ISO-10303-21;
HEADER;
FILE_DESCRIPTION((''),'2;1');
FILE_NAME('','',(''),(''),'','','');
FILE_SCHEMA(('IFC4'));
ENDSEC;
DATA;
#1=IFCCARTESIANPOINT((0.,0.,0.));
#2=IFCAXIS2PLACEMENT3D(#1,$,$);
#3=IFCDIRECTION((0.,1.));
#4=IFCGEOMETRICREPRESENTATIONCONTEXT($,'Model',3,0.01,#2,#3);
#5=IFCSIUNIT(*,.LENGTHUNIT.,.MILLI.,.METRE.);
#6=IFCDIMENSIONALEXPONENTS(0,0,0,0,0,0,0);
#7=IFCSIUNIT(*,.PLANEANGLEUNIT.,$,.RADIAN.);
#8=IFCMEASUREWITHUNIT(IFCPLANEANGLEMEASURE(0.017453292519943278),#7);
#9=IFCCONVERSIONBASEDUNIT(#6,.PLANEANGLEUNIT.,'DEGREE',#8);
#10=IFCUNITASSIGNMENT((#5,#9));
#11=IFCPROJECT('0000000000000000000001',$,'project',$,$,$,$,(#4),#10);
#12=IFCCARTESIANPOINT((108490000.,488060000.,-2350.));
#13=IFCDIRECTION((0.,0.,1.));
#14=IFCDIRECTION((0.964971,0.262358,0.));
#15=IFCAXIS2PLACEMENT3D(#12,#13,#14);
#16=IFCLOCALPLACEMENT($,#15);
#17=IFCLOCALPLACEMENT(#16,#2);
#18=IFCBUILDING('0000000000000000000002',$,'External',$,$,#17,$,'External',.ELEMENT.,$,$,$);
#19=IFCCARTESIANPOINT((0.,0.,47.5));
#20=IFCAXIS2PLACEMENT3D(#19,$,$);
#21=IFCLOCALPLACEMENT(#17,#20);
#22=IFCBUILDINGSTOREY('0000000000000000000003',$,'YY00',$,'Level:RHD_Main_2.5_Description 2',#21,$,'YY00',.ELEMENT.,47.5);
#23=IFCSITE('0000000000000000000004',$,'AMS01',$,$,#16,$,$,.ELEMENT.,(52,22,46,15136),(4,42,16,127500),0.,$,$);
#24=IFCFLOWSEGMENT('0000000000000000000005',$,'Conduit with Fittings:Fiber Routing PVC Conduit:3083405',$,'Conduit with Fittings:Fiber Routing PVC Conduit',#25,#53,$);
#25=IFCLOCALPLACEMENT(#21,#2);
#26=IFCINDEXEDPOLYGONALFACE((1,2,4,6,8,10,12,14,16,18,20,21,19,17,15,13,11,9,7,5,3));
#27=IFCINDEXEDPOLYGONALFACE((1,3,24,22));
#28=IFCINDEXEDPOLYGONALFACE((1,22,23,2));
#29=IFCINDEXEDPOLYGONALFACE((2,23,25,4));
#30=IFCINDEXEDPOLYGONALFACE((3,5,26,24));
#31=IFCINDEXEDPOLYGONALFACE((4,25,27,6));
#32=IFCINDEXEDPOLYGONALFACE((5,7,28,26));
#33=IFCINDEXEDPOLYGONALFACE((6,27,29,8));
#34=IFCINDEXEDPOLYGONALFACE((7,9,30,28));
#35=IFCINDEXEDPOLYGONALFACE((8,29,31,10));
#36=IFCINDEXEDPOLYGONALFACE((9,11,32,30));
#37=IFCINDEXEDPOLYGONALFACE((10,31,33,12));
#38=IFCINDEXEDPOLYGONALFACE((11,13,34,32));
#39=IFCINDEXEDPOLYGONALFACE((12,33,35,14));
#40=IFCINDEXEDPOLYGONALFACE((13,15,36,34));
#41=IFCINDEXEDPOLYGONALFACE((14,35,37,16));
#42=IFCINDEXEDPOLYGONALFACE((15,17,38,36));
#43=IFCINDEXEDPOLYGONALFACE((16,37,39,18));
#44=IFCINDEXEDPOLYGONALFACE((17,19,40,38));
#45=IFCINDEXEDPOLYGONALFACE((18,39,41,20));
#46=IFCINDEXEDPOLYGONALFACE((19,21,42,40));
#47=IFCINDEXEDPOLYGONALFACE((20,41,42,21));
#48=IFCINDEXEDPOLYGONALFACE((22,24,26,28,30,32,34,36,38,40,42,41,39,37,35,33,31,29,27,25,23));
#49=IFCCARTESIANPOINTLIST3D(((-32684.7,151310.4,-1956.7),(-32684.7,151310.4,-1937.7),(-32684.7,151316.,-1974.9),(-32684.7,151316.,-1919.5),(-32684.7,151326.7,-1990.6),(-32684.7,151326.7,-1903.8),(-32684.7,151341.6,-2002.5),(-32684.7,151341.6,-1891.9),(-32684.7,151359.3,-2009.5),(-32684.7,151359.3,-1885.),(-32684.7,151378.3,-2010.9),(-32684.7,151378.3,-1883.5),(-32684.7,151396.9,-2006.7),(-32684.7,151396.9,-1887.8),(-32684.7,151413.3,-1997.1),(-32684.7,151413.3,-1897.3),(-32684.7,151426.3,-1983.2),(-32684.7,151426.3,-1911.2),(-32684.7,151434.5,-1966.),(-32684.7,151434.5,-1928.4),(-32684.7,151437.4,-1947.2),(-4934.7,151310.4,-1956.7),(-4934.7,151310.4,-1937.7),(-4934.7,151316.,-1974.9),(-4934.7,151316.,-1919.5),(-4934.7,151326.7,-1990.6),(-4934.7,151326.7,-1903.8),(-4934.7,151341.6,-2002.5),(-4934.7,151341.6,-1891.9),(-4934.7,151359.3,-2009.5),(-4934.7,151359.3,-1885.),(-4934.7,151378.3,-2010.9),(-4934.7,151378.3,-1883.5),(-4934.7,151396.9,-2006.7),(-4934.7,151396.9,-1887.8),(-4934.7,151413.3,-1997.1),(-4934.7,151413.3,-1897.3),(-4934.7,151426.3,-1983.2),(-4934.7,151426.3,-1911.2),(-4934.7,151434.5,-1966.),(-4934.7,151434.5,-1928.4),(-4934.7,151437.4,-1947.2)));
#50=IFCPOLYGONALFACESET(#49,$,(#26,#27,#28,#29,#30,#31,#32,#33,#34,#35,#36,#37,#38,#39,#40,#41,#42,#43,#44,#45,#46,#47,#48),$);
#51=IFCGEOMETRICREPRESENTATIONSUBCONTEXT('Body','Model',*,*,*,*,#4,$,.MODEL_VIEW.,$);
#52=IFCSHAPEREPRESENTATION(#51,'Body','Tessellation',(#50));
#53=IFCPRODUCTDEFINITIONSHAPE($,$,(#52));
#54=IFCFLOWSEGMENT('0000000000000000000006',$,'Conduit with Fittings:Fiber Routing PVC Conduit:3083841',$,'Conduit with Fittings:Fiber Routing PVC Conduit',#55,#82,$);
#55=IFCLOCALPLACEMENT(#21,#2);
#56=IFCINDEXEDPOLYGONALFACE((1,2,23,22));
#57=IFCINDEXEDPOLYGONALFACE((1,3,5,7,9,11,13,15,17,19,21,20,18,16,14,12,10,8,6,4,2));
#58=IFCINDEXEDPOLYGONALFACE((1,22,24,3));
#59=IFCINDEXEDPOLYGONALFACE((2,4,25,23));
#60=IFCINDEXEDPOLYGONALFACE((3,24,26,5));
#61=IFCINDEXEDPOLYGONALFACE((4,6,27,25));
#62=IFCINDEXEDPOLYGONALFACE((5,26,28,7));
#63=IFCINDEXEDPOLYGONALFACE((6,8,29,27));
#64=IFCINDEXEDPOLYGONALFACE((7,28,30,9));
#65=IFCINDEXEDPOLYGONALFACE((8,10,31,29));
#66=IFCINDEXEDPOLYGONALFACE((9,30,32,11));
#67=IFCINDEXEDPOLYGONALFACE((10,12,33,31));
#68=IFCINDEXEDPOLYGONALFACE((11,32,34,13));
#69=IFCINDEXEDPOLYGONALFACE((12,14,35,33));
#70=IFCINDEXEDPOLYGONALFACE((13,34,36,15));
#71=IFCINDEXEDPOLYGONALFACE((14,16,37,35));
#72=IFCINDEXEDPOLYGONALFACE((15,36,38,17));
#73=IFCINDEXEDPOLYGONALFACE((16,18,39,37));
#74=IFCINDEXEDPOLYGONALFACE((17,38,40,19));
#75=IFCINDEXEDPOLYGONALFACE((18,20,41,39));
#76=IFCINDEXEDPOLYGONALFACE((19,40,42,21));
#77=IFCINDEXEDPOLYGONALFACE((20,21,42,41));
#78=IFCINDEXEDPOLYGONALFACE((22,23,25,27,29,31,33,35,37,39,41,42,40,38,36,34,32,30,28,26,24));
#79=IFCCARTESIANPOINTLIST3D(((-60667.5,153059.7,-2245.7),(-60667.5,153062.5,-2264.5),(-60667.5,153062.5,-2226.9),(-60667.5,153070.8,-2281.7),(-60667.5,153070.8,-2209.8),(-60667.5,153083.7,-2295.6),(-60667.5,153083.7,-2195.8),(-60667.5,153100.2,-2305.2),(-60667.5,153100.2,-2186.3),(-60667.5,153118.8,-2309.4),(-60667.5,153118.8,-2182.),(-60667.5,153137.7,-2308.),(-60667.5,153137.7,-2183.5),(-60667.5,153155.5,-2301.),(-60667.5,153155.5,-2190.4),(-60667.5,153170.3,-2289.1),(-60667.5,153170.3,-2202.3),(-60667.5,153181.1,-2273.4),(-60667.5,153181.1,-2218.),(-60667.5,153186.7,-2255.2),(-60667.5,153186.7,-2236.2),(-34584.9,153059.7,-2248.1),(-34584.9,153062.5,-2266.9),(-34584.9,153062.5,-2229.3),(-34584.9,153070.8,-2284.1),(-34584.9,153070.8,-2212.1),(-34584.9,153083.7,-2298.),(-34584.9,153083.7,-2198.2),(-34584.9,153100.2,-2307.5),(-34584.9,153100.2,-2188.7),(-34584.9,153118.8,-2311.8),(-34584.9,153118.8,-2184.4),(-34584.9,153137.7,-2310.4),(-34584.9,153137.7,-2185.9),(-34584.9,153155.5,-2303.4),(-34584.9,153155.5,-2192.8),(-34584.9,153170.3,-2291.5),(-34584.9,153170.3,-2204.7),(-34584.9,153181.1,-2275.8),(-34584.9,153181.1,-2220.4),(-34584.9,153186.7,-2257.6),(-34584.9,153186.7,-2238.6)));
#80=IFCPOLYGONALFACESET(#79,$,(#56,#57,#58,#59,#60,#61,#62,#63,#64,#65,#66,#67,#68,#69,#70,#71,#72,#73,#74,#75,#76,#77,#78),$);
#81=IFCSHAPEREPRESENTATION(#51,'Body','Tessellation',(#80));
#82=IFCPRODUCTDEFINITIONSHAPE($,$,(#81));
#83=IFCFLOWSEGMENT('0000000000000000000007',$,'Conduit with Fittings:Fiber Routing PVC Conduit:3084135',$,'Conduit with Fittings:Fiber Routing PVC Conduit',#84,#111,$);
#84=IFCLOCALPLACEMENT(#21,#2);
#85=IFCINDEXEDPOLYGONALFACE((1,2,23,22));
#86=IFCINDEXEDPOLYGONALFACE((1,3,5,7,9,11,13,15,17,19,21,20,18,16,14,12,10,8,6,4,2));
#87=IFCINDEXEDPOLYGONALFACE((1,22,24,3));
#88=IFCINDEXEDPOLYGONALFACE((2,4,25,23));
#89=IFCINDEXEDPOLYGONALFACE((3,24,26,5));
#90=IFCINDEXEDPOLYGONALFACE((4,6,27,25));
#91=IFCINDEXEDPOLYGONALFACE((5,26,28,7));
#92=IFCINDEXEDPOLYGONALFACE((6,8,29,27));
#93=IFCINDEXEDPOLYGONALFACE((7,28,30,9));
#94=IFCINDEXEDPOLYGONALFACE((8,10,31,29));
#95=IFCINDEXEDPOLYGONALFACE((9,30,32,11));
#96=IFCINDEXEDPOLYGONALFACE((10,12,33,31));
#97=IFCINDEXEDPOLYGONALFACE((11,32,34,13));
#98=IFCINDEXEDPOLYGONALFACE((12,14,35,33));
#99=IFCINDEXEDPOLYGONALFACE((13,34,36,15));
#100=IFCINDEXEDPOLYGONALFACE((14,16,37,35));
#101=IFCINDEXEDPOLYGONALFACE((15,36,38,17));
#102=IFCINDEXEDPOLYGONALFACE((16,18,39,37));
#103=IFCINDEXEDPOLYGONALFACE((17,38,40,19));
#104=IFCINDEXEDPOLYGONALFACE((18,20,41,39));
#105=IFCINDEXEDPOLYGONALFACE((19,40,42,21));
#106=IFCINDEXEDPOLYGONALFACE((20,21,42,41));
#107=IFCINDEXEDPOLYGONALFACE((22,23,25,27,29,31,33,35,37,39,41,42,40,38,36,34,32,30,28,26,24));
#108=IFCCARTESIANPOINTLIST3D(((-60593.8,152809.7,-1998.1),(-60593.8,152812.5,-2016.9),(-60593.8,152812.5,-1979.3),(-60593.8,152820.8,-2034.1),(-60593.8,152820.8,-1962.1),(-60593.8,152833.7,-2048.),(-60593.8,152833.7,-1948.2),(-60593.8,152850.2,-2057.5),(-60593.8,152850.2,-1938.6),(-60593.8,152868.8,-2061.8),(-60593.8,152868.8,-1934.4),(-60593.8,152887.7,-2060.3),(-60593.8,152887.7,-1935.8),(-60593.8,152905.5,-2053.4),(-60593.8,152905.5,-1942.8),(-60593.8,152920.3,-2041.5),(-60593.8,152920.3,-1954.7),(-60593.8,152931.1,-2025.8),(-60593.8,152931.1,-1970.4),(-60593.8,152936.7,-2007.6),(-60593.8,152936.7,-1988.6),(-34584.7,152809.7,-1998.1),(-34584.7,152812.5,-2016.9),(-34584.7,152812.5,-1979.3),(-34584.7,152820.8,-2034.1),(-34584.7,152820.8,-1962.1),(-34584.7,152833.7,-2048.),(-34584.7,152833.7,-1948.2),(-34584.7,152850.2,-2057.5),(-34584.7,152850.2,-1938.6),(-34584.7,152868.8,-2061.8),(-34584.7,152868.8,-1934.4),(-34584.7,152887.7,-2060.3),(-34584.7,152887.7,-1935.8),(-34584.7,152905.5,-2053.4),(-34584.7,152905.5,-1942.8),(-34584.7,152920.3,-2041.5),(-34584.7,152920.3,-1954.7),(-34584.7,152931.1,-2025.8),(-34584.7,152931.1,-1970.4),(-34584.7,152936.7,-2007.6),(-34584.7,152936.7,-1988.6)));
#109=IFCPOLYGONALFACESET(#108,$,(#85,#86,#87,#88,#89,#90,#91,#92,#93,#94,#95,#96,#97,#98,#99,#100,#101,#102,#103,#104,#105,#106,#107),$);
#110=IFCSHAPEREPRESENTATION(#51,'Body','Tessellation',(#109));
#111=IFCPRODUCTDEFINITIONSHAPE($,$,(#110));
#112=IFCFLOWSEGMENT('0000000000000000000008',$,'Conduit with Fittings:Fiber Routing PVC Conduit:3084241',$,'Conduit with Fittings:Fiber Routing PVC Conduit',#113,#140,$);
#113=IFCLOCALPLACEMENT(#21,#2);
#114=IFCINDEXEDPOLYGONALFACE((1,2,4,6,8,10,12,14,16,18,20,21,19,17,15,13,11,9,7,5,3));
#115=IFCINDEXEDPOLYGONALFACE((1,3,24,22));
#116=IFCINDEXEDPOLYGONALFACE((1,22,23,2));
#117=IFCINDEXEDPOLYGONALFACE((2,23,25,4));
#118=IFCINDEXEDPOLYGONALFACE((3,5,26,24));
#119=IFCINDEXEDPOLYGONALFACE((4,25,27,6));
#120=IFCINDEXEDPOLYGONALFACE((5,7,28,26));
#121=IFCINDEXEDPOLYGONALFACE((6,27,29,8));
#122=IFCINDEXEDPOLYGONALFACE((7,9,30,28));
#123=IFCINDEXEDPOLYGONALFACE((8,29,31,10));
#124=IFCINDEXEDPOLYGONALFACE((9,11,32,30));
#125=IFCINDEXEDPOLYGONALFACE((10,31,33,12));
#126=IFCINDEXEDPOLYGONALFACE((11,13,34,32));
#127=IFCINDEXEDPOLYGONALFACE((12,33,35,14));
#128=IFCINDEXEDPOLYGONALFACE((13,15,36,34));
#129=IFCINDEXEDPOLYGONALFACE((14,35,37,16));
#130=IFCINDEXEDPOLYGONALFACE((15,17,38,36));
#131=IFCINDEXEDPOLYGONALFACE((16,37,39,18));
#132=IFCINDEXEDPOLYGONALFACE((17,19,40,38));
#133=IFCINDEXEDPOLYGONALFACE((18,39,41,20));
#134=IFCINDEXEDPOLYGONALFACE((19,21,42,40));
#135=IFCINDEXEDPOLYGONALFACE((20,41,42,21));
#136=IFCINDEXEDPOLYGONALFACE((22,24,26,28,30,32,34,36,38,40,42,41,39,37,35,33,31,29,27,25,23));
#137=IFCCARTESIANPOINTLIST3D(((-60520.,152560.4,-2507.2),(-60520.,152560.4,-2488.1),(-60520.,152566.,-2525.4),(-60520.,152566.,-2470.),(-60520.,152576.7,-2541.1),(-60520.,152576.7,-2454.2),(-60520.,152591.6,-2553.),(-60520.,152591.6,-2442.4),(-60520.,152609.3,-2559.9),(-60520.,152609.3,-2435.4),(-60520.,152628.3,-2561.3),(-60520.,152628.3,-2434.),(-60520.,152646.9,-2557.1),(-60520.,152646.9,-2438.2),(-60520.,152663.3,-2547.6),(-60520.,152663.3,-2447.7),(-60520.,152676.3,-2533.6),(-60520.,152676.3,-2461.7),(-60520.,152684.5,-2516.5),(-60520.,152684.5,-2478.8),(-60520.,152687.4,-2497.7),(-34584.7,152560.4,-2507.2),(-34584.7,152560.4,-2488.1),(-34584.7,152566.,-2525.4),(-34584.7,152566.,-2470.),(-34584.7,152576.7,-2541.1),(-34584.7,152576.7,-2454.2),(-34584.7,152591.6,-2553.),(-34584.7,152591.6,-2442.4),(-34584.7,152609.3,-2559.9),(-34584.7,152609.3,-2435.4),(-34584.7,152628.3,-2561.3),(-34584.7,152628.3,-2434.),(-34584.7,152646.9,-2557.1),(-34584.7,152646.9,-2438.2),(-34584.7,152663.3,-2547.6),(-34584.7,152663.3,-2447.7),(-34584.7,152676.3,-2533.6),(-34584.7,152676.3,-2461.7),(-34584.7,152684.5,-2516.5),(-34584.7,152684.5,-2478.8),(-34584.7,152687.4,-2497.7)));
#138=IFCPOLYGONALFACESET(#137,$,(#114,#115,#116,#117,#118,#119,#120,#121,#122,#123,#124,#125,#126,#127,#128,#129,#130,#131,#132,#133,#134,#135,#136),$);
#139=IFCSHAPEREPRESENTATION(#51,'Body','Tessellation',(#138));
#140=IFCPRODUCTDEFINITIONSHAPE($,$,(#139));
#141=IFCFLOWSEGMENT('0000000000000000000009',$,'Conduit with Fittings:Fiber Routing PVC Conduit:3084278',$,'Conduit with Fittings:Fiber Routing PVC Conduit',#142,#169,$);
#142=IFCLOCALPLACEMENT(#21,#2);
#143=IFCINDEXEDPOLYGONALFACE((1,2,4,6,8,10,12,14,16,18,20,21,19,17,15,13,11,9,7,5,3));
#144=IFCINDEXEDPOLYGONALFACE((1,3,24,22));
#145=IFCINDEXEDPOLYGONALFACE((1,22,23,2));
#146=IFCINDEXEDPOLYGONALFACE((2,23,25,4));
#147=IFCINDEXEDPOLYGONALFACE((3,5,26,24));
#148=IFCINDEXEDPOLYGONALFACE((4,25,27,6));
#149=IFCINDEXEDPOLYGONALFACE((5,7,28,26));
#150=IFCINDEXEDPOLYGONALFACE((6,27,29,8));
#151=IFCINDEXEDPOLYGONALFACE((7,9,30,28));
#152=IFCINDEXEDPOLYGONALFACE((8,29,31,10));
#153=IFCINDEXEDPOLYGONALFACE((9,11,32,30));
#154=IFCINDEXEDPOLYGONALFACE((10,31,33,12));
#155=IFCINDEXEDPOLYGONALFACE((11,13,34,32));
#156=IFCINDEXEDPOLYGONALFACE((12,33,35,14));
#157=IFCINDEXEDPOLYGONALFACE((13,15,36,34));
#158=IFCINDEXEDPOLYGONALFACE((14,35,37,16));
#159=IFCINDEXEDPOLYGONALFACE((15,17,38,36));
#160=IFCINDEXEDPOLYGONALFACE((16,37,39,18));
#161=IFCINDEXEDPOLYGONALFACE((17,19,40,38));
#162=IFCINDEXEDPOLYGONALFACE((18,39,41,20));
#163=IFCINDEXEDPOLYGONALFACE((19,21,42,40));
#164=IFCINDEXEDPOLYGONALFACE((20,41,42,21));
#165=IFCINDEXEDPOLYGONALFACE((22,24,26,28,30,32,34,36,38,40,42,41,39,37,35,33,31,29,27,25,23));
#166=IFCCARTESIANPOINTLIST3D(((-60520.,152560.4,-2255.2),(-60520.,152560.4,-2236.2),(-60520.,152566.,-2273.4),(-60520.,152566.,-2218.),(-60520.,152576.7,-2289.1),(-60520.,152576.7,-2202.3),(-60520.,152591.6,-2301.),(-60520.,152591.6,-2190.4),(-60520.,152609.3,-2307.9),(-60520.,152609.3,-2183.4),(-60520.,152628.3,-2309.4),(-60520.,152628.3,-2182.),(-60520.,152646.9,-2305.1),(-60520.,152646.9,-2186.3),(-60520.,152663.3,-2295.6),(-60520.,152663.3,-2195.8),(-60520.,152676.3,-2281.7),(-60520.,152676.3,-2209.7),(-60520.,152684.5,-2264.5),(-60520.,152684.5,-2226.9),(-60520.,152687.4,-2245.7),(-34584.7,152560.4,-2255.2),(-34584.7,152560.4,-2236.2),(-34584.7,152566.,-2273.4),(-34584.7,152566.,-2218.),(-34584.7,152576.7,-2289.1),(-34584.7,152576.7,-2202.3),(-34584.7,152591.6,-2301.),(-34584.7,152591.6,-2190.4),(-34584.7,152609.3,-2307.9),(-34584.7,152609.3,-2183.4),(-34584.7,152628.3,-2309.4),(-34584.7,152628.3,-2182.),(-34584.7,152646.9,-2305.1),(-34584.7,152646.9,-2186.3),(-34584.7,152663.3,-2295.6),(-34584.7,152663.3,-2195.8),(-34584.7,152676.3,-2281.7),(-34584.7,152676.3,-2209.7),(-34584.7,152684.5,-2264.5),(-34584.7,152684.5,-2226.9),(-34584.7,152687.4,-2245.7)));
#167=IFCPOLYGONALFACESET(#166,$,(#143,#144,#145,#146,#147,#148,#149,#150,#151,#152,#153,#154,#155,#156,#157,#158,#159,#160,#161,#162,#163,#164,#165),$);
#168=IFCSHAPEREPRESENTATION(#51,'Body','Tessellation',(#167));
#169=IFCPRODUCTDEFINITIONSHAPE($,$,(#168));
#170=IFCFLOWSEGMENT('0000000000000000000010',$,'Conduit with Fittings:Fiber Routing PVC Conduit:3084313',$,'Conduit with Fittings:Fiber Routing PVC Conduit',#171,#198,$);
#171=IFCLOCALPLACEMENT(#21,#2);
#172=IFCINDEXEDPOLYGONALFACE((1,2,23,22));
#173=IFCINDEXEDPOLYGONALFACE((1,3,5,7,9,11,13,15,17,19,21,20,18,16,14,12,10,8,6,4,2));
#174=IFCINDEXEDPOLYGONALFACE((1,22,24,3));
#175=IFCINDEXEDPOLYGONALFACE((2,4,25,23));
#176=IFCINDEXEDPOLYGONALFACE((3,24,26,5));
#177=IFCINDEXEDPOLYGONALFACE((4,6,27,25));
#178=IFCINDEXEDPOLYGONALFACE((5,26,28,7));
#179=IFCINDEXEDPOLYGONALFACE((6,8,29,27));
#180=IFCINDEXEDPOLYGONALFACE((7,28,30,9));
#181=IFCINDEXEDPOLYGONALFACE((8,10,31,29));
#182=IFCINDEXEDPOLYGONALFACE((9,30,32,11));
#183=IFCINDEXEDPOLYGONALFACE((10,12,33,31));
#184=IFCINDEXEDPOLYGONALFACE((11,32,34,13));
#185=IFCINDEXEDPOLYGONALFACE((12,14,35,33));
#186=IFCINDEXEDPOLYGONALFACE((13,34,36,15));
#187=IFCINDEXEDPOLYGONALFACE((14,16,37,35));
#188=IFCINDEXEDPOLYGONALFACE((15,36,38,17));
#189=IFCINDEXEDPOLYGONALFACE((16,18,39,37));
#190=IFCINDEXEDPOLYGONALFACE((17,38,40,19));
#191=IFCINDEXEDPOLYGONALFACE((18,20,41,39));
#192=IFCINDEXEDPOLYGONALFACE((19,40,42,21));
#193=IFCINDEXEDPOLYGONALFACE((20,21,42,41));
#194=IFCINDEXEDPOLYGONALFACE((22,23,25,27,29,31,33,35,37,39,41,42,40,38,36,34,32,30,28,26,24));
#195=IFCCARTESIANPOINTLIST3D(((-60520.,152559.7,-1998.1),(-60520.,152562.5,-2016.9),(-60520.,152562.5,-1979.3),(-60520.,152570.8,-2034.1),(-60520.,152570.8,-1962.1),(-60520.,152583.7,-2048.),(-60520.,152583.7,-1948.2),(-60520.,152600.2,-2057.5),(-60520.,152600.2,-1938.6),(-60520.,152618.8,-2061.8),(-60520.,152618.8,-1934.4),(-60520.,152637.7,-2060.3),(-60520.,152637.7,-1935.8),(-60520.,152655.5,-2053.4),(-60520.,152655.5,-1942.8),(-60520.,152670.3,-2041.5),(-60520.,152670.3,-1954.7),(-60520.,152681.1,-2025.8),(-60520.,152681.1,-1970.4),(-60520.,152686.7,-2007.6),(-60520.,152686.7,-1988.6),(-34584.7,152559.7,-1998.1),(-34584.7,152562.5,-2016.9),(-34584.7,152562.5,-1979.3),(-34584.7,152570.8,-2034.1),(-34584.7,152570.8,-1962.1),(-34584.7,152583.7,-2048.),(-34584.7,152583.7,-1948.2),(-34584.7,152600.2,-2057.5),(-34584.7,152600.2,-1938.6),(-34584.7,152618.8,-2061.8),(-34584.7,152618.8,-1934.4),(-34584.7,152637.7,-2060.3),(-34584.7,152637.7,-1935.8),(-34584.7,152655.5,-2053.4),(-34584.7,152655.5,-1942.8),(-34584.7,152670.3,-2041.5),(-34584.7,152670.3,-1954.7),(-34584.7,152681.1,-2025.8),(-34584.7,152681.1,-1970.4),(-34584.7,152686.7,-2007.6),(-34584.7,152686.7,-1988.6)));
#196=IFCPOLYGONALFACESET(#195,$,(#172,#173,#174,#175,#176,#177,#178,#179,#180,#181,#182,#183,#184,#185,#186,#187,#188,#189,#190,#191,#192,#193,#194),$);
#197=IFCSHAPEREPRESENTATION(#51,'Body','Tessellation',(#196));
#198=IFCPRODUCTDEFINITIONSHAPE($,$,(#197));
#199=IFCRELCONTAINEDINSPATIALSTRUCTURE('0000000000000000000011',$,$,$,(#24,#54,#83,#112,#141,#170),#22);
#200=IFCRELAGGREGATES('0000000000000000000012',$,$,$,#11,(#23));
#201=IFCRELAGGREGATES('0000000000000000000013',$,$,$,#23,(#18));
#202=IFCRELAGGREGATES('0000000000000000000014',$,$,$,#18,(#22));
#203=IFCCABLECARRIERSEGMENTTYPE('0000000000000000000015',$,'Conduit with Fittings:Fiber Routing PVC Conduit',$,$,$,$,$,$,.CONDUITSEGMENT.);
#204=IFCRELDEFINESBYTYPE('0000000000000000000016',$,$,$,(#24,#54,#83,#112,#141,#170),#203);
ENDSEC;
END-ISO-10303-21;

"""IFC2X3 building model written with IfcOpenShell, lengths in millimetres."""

from ifc_helpers import new_model, entity, si_unit, converted_unit, direction, frame, frame_2d, origin, origin_2d_with_axis, place, context, subcontext, project, spatial, circle, extrude, type_object, element, save


model = new_model("IFC2X3")

# Units and contexts
model_context = context("Model", 3, precision=0.01, world=origin(), true_north=direction((0.0, 1.0)))
body_context = subcontext(model_context, "Body", "Model", "MODEL_VIEW")
ifc_project = project(units=[si_unit("LENGTHUNIT", "METRE", prefix="MILLI"), converted_unit("PLANEANGLEUNIT", "DEGREE", entity("IfcPlaneAngleMeasure", 0.017453292519943278), si_unit("PLANEANGLEUNIT", "RADIAN"), dimensions=[0, 0, 0, 0, 0, 0, 0])], contexts=[model_context])

# Site, building, storey
site_placement = place(None, frame((108490000.0, 488060000.0, -2350.0), z_axis=(0.0, 0.0, 1.0), x_axis=(0.964971, 0.262358, 0.0)))
site = spatial("IfcSite", under=ifc_project, at=site_placement, Name="AMS01", CompositionType="ELEMENT", RefLatitude=(52, 22, 46, 15136), RefLongitude=(4, 42, 16, 127500), RefElevation=0.0)
building_placement = place(site_placement, origin())
building = spatial("IfcBuilding", under=site, at=building_placement, Name="External", LongName="External", CompositionType="ELEMENT")
storey_placement = place(building_placement, frame((0.0, 0.0, 47.5)))
storey = spatial("IfcBuildingStorey", under=building, at=storey_placement, Name="YY00", ObjectType="Level:RHD_Main_2.5_Description 2", LongName="YY00", CompositionType="ELEMENT", Elevation=47.5)

# Flow segments
cable_carrier_segment_type = type_object("IfcCableCarrierSegmentType", Name="Conduit with Fittings:Fiber Routing PVC Conduit", PredefinedType="CONDUITSEGMENT")
flow_segment_1_placement = place(storey_placement, origin())
element("IfcFlowSegment", 1, at=flow_segment_1_placement, inside=storey, type_object=cable_carrier_segment_type, Name="Conduit with Fittings:Fiber Routing PVC Conduit:3083405", ObjectType="Conduit with Fittings:Fiber Routing PVC Conduit", context=body_context, shape_type="SweptSolid", body=[
    extrude(circle(Radius=63.9, at=frame_2d((0.0, 0.0), x_axis=(1.0, 0.0))), frame((-32684.7, 151373.5, -1947.2), z_axis=(1.0, 0.0, 0.0), x_axis=(0.0, 1.0, 0.0)), (0.0, 0.0, 1.0), 27750.0),
])
flow_segment_2_placement = place(storey_placement, origin())
element("IfcFlowSegment", 2, at=flow_segment_2_placement, inside=storey, type_object=cable_carrier_segment_type, Name="Conduit with Fittings:Fiber Routing PVC Conduit:3083841", ObjectType="Conduit with Fittings:Fiber Routing PVC Conduit", context=body_context, shape_type="SweptSolid", body=[
    extrude(circle(Radius=63.9, at=frame_2d((0.0, 0.0), x_axis=(1.0, 0.0))), frame((-60667.5, 153123.5, -2245.7), z_axis=(1.0, 0.0, -0.000091), x_axis=(0.0, -1.0, 0.0)), (0.0, 0.0, 1.0), 26082.7),
])
flow_segment_3_placement = place(storey_placement, origin())
element("IfcFlowSegment", 3, at=flow_segment_3_placement, inside=storey, type_object=cable_carrier_segment_type, Name="Conduit with Fittings:Fiber Routing PVC Conduit:3084135", ObjectType="Conduit with Fittings:Fiber Routing PVC Conduit", context=body_context, shape_type="SweptSolid", body=[
    extrude(circle(Radius=63.9, at=origin_2d_with_axis()), frame((-60593.8, 152873.5, -1998.1), z_axis=(1.0, 0.0, 0.0), x_axis=(0.0, -1.0, 0.0)), (0.0, 0.0, 1.0), 26009.1),
])
flow_segment_4_placement = place(storey_placement, origin())
element("IfcFlowSegment", 4, at=flow_segment_4_placement, inside=storey, type_object=cable_carrier_segment_type, Name="Conduit with Fittings:Fiber Routing PVC Conduit:3084241", ObjectType="Conduit with Fittings:Fiber Routing PVC Conduit", context=body_context, shape_type="SweptSolid", body=[
    extrude(circle(Radius=63.9, at=frame_2d((0.0, 0.0), x_axis=(1.0, 0.0))), frame((-60520.0, 152623.5, -2497.7), z_axis=(1.0, 0.0, 0.0), x_axis=(0.0, 1.0, 0.0)), (0.0, 0.0, 1.0), 25935.3),
])
flow_segment_5_placement = place(storey_placement, origin())
element("IfcFlowSegment", 5, at=flow_segment_5_placement, inside=storey, type_object=cable_carrier_segment_type, Name="Conduit with Fittings:Fiber Routing PVC Conduit:3084278", ObjectType="Conduit with Fittings:Fiber Routing PVC Conduit", context=body_context, shape_type="SweptSolid", body=[
    extrude(circle(Radius=63.9, at=frame_2d((0.0, 0.0), x_axis=(1.0, 0.0))), frame((-60520.0, 152623.5, -2245.7), z_axis=(1.0, 0.0, 0.0), x_axis=(0.0, 1.0, 0.0)), (0.0, 0.0, 1.0), 25935.3),
])
flow_segment_6_placement = place(storey_placement, origin())
element("IfcFlowSegment", 6, at=flow_segment_6_placement, inside=storey, type_object=cable_carrier_segment_type, Name="Conduit with Fittings:Fiber Routing PVC Conduit:3084313", ObjectType="Conduit with Fittings:Fiber Routing PVC Conduit", context=body_context, shape_type="SweptSolid", body=[
    extrude(circle(Radius=63.9, at=origin_2d_with_axis()), frame((-60520.0, 152623.5, -1998.1), z_axis=(1.0, 0.0, 0.0), x_axis=(0.0, -1.0, 0.0)), (0.0, 0.0, 1.0), 25935.3),
])

save(model, "model.ifc")
